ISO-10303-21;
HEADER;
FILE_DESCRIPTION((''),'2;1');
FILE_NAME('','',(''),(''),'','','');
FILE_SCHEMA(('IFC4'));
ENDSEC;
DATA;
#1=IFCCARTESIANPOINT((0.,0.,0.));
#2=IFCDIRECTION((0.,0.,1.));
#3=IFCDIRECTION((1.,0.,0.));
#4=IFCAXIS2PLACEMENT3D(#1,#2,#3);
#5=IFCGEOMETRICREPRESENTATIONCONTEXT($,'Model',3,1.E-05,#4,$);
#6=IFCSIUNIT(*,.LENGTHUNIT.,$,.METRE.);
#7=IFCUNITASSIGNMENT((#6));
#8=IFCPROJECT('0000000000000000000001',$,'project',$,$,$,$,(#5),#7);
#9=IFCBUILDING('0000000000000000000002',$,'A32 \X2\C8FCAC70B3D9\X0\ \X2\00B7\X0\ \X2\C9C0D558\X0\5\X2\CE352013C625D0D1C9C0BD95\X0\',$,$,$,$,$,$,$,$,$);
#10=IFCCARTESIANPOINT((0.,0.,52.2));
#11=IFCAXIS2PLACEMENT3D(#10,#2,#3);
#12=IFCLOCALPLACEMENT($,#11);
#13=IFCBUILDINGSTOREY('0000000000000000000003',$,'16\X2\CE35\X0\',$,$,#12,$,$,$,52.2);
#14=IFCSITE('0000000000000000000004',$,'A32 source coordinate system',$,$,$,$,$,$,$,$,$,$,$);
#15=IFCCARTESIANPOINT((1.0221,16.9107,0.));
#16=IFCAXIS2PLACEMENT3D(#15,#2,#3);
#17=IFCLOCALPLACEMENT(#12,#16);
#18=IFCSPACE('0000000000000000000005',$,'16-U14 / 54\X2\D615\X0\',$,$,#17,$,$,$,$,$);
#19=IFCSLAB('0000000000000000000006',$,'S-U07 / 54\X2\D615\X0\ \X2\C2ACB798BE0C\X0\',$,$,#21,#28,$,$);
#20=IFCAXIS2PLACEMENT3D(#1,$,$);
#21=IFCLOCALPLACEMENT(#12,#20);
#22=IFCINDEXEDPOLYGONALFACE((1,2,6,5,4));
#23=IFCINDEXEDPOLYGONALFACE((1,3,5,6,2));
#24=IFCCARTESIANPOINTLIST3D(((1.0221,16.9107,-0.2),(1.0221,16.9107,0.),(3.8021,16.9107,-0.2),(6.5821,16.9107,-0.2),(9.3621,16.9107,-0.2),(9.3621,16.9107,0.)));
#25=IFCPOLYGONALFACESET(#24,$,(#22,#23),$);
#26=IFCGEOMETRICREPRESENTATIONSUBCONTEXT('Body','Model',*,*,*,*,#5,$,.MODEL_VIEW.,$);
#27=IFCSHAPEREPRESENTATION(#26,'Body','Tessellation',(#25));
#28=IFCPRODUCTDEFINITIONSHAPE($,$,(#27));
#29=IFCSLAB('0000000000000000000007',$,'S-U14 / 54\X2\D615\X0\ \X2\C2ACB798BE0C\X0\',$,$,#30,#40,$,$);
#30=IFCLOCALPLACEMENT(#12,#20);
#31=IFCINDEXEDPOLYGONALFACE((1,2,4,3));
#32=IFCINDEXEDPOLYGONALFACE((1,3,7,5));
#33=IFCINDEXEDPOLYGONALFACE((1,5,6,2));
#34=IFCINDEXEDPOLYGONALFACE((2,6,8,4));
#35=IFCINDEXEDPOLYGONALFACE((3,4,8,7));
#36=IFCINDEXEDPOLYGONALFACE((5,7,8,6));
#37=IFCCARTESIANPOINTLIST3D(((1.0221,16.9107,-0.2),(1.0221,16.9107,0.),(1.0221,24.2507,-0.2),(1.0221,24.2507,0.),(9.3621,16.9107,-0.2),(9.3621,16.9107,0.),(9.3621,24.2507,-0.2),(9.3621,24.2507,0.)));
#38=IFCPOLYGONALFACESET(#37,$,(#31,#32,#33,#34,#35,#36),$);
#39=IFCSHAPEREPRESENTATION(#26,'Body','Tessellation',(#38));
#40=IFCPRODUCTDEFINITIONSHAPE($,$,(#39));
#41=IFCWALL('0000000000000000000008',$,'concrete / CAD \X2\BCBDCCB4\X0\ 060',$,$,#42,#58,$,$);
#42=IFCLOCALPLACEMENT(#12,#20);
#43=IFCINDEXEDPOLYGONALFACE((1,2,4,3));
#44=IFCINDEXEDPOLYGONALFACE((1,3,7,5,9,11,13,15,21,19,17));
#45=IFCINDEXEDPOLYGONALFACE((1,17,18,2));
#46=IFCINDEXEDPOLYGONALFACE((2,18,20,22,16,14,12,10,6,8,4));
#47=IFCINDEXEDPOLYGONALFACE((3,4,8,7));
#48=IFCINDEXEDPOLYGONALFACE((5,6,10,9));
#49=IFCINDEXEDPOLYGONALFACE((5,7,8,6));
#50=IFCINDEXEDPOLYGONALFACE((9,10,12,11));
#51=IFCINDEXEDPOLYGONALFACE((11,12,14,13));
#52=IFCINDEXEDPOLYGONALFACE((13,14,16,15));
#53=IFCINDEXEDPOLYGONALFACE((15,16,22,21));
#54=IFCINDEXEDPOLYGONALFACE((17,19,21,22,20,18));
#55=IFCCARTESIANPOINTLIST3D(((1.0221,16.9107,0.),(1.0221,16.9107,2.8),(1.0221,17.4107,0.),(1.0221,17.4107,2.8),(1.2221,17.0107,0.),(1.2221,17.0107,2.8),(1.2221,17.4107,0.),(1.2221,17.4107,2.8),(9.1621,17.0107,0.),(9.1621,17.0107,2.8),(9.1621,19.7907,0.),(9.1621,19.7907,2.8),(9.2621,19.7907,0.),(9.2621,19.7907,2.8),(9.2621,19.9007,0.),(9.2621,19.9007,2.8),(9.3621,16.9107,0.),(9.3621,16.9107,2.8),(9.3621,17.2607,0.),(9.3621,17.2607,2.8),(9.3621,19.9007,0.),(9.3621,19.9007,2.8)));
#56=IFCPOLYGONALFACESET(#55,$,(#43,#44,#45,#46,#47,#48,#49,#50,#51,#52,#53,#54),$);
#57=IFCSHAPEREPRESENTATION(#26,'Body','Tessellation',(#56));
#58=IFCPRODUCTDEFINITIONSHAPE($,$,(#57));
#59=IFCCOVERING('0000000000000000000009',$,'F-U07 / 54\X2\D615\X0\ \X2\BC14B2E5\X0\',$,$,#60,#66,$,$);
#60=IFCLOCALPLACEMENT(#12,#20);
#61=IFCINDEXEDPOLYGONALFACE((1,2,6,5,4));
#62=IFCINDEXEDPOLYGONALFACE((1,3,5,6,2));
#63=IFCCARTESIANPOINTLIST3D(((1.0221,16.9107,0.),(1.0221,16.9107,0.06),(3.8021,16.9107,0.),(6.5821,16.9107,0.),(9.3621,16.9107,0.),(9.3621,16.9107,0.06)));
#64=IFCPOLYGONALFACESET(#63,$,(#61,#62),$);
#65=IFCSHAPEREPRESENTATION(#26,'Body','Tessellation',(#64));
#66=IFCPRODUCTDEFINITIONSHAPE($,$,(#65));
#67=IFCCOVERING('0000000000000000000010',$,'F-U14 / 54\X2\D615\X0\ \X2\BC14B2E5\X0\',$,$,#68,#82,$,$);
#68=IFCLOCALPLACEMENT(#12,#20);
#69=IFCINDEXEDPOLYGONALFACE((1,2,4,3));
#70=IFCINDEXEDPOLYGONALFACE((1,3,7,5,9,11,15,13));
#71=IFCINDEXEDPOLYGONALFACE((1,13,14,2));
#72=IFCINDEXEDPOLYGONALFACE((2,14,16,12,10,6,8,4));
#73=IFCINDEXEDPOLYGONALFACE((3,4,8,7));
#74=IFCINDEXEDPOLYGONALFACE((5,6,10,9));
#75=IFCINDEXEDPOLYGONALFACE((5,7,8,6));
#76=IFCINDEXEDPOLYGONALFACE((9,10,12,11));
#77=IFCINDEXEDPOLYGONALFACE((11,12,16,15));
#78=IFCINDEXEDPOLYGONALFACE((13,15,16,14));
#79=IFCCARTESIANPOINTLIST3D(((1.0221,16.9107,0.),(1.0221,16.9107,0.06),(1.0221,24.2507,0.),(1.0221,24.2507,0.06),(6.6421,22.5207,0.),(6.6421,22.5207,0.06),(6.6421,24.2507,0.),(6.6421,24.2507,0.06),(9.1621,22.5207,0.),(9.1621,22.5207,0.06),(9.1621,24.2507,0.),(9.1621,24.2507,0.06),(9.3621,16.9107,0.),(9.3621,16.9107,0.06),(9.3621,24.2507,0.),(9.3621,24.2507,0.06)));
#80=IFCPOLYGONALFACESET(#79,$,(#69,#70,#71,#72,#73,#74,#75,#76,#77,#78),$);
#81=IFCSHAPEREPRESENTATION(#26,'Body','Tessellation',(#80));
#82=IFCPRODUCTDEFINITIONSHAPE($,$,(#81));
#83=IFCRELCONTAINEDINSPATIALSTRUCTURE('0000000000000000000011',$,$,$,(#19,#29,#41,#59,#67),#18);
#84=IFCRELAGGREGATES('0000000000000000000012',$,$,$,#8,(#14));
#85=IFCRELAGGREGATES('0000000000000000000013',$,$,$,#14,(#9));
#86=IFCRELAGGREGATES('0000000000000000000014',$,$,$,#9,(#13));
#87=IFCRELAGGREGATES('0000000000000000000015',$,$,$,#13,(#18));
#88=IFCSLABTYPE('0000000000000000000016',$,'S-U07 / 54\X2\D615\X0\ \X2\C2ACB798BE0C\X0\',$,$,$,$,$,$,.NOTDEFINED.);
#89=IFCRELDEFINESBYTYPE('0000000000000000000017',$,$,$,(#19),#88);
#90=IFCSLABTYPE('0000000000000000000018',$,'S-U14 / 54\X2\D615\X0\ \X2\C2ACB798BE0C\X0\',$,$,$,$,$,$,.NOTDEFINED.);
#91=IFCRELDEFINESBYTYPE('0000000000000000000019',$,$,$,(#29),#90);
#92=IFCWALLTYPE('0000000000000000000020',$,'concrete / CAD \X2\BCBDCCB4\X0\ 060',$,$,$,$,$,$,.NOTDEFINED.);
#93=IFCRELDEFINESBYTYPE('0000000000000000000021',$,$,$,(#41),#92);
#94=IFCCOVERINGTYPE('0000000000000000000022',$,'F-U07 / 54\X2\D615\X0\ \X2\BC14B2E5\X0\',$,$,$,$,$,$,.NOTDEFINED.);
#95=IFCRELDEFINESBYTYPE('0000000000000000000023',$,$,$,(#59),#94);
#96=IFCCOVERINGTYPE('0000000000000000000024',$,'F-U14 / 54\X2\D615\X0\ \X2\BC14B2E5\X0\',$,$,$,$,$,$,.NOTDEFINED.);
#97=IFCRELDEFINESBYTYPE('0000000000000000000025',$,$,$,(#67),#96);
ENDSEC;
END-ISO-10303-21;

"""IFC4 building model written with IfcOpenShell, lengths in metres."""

from ifc_helpers import new_model, si_unit, frame, origin, origin_with_axes, place, context, subcontext, project, spatial, polyline, outline, extrude, source, transform, mapped, type_object, type_shapes, element, save


model = new_model("IFC4")

# Units and contexts
model_context = context("Model", 3, precision=1e-05, world=origin_with_axes())
body_context = subcontext(model_context, "Body", "Model", "MODEL_VIEW")
ifc_project = project(units=[si_unit("LENGTHUNIT", "METRE")], contexts=[model_context])

# Site, building, storey, space
storey_placement = place(None, frame((0.0, 0.0, 52.2), z_axis=(0.0, 0.0, 1.0), x_axis=(1.0, 0.0, 0.0)))
space_1_placement = place(storey_placement, frame((1.0221, 16.9107, 0.0), z_axis=(0.0, 0.0, 1.0), x_axis=(1.0, 0.0, 0.0)))
site = spatial("IfcSite", under=ifc_project, Name="A32 source coordinate system")
building = spatial("IfcBuilding", under=site, Name="A32 주거동 · 지하5층–옥탑지붕")
storey = spatial("IfcBuildingStorey", under=building, at=storey_placement, Name="16층", Elevation=52.2)
space_1 = spatial("IfcSpace", under=storey, at=space_1_placement, Name="16-U14 / 54형")

# Slabs
slab_type_1 = type_object("IfcSlabType", Name="S-U07 / 54형 슬래브", PredefinedType="NOTDEFINED")
shared_shape_1 = source(origin(), body_context, "Body", "SweptSolid", [
    extrude(outline(polyline([(0.0, 0.0), (0.0, 0.0), (8.34, 0.0), (8.34, 0.0), (0.0, 0.0)])), frame((0.0, 0.0, -0.2)), (0.0, 0.0, 1.0), 0.2),
])
type_shapes(slab_type_1, [shared_shape_1])
slab_1_placement = place(space_1_placement, origin_with_axes())
element("IfcSlab", 1, at=slab_1_placement, inside=space_1, type_object=slab_type_1, Name="S-U07 / 54형 슬래브", context=body_context, shape_type="MappedRepresentation", body=[
    mapped(shared_shape_1, transform((0.0, 0.0, 0.0), scale=1.0)),
])
slab_type_2 = type_object("IfcSlabType", Name="S-U14 / 54형 슬래브", PredefinedType="NOTDEFINED")
shared_shape_2 = source(origin(), body_context, "Body", "SweptSolid", [
    extrude(outline(polyline([(0.0, 0.0), (0.0, 7.34), (8.34, 7.34), (8.34, 0.0), (0.0, 0.0)])), frame((0.0, 0.0, -0.2)), (0.0, 0.0, 1.0), 0.2),
])
type_shapes(slab_type_2, [shared_shape_2])
slab_2_placement = place(space_1_placement, origin_with_axes())
element("IfcSlab", 2, at=slab_2_placement, inside=space_1, type_object=slab_type_2, Name="S-U14 / 54형 슬래브", context=body_context, shape_type="MappedRepresentation", body=[
    mapped(shared_shape_2, transform((0.0, 0.0, 0.0), scale=1.0)),
])

# Wall
wall_type_1 = type_object("IfcWallType", Name="concrete / CAD 벽체 060", PredefinedType="NOTDEFINED")
shared_shape_3 = source(origin(), body_context, "Body", "SweptSolid", [
    extrude(outline(polyline([(0.2, 0.5), (0.2, 0.1), (8.14, 0.1), (8.14, 2.88), (8.24, 2.88), (8.24, 2.99), (8.34, 2.99), (8.34, 0.35), (8.34, 0.35), (8.34, 0.0), (0.0, 0.0), (0.0, 0.5), (0.2, 0.5)])), origin(), (0.0, 0.0, 1.0), 2.8),
])
type_shapes(wall_type_1, [shared_shape_3])
wall_1_placement = place(space_1_placement, origin_with_axes())
element("IfcWall", 3, at=wall_1_placement, inside=space_1, type_object=wall_type_1, Name="concrete / CAD 벽체 060", context=body_context, shape_type="MappedRepresentation", body=[
    mapped(shared_shape_3, transform((0.0, 0.0, 0.0), scale=1.0)),
])

# Coverings
covering_type_1 = type_object("IfcCoveringType", Name="F-U07 / 54형 바닥", PredefinedType="NOTDEFINED")
shared_shape_4 = source(origin(), body_context, "Body", "SweptSolid", [
    extrude(outline(polyline([(0.0, 0.0), (0.0, 0.0), (8.34, 0.0), (8.34, 0.0), (0.0, 0.0)])), origin(), (0.0, 0.0, 1.0), 0.06),
])
type_shapes(covering_type_1, [shared_shape_4])
covering_1_placement = place(space_1_placement, origin_with_axes())
element("IfcCovering", 4, at=covering_1_placement, inside=space_1, type_object=covering_type_1, Name="F-U07 / 54형 바닥", context=body_context, shape_type="MappedRepresentation", body=[
    mapped(shared_shape_4, transform((0.0, 0.0, 0.0), scale=1.0)),
])
covering_type_2 = type_object("IfcCoveringType", Name="F-U14 / 54형 바닥", PredefinedType="NOTDEFINED")
shared_shape_5 = source(origin(), body_context, "Body", "SweptSolid", [
    extrude(outline(polyline([(8.14, 7.34), (8.34, 7.34), (8.34, 0.0), (0.0, 0.0), (0.0, 7.34), (5.62, 7.34), (5.62, 5.61), (8.14, 5.61), (8.14, 7.34)])), origin(), (0.0, 0.0, 1.0), 0.06),
])
type_shapes(covering_type_2, [shared_shape_5])
covering_2_placement = place(space_1_placement, origin_with_axes())
element("IfcCovering", 5, at=covering_2_placement, inside=space_1, type_object=covering_type_2, Name="F-U14 / 54형 바닥", context=body_context, shape_type="MappedRepresentation", body=[
    mapped(shared_shape_5, transform((0.0, 0.0, 0.0), scale=1.0)),
])

save(model, "model.ifc")
